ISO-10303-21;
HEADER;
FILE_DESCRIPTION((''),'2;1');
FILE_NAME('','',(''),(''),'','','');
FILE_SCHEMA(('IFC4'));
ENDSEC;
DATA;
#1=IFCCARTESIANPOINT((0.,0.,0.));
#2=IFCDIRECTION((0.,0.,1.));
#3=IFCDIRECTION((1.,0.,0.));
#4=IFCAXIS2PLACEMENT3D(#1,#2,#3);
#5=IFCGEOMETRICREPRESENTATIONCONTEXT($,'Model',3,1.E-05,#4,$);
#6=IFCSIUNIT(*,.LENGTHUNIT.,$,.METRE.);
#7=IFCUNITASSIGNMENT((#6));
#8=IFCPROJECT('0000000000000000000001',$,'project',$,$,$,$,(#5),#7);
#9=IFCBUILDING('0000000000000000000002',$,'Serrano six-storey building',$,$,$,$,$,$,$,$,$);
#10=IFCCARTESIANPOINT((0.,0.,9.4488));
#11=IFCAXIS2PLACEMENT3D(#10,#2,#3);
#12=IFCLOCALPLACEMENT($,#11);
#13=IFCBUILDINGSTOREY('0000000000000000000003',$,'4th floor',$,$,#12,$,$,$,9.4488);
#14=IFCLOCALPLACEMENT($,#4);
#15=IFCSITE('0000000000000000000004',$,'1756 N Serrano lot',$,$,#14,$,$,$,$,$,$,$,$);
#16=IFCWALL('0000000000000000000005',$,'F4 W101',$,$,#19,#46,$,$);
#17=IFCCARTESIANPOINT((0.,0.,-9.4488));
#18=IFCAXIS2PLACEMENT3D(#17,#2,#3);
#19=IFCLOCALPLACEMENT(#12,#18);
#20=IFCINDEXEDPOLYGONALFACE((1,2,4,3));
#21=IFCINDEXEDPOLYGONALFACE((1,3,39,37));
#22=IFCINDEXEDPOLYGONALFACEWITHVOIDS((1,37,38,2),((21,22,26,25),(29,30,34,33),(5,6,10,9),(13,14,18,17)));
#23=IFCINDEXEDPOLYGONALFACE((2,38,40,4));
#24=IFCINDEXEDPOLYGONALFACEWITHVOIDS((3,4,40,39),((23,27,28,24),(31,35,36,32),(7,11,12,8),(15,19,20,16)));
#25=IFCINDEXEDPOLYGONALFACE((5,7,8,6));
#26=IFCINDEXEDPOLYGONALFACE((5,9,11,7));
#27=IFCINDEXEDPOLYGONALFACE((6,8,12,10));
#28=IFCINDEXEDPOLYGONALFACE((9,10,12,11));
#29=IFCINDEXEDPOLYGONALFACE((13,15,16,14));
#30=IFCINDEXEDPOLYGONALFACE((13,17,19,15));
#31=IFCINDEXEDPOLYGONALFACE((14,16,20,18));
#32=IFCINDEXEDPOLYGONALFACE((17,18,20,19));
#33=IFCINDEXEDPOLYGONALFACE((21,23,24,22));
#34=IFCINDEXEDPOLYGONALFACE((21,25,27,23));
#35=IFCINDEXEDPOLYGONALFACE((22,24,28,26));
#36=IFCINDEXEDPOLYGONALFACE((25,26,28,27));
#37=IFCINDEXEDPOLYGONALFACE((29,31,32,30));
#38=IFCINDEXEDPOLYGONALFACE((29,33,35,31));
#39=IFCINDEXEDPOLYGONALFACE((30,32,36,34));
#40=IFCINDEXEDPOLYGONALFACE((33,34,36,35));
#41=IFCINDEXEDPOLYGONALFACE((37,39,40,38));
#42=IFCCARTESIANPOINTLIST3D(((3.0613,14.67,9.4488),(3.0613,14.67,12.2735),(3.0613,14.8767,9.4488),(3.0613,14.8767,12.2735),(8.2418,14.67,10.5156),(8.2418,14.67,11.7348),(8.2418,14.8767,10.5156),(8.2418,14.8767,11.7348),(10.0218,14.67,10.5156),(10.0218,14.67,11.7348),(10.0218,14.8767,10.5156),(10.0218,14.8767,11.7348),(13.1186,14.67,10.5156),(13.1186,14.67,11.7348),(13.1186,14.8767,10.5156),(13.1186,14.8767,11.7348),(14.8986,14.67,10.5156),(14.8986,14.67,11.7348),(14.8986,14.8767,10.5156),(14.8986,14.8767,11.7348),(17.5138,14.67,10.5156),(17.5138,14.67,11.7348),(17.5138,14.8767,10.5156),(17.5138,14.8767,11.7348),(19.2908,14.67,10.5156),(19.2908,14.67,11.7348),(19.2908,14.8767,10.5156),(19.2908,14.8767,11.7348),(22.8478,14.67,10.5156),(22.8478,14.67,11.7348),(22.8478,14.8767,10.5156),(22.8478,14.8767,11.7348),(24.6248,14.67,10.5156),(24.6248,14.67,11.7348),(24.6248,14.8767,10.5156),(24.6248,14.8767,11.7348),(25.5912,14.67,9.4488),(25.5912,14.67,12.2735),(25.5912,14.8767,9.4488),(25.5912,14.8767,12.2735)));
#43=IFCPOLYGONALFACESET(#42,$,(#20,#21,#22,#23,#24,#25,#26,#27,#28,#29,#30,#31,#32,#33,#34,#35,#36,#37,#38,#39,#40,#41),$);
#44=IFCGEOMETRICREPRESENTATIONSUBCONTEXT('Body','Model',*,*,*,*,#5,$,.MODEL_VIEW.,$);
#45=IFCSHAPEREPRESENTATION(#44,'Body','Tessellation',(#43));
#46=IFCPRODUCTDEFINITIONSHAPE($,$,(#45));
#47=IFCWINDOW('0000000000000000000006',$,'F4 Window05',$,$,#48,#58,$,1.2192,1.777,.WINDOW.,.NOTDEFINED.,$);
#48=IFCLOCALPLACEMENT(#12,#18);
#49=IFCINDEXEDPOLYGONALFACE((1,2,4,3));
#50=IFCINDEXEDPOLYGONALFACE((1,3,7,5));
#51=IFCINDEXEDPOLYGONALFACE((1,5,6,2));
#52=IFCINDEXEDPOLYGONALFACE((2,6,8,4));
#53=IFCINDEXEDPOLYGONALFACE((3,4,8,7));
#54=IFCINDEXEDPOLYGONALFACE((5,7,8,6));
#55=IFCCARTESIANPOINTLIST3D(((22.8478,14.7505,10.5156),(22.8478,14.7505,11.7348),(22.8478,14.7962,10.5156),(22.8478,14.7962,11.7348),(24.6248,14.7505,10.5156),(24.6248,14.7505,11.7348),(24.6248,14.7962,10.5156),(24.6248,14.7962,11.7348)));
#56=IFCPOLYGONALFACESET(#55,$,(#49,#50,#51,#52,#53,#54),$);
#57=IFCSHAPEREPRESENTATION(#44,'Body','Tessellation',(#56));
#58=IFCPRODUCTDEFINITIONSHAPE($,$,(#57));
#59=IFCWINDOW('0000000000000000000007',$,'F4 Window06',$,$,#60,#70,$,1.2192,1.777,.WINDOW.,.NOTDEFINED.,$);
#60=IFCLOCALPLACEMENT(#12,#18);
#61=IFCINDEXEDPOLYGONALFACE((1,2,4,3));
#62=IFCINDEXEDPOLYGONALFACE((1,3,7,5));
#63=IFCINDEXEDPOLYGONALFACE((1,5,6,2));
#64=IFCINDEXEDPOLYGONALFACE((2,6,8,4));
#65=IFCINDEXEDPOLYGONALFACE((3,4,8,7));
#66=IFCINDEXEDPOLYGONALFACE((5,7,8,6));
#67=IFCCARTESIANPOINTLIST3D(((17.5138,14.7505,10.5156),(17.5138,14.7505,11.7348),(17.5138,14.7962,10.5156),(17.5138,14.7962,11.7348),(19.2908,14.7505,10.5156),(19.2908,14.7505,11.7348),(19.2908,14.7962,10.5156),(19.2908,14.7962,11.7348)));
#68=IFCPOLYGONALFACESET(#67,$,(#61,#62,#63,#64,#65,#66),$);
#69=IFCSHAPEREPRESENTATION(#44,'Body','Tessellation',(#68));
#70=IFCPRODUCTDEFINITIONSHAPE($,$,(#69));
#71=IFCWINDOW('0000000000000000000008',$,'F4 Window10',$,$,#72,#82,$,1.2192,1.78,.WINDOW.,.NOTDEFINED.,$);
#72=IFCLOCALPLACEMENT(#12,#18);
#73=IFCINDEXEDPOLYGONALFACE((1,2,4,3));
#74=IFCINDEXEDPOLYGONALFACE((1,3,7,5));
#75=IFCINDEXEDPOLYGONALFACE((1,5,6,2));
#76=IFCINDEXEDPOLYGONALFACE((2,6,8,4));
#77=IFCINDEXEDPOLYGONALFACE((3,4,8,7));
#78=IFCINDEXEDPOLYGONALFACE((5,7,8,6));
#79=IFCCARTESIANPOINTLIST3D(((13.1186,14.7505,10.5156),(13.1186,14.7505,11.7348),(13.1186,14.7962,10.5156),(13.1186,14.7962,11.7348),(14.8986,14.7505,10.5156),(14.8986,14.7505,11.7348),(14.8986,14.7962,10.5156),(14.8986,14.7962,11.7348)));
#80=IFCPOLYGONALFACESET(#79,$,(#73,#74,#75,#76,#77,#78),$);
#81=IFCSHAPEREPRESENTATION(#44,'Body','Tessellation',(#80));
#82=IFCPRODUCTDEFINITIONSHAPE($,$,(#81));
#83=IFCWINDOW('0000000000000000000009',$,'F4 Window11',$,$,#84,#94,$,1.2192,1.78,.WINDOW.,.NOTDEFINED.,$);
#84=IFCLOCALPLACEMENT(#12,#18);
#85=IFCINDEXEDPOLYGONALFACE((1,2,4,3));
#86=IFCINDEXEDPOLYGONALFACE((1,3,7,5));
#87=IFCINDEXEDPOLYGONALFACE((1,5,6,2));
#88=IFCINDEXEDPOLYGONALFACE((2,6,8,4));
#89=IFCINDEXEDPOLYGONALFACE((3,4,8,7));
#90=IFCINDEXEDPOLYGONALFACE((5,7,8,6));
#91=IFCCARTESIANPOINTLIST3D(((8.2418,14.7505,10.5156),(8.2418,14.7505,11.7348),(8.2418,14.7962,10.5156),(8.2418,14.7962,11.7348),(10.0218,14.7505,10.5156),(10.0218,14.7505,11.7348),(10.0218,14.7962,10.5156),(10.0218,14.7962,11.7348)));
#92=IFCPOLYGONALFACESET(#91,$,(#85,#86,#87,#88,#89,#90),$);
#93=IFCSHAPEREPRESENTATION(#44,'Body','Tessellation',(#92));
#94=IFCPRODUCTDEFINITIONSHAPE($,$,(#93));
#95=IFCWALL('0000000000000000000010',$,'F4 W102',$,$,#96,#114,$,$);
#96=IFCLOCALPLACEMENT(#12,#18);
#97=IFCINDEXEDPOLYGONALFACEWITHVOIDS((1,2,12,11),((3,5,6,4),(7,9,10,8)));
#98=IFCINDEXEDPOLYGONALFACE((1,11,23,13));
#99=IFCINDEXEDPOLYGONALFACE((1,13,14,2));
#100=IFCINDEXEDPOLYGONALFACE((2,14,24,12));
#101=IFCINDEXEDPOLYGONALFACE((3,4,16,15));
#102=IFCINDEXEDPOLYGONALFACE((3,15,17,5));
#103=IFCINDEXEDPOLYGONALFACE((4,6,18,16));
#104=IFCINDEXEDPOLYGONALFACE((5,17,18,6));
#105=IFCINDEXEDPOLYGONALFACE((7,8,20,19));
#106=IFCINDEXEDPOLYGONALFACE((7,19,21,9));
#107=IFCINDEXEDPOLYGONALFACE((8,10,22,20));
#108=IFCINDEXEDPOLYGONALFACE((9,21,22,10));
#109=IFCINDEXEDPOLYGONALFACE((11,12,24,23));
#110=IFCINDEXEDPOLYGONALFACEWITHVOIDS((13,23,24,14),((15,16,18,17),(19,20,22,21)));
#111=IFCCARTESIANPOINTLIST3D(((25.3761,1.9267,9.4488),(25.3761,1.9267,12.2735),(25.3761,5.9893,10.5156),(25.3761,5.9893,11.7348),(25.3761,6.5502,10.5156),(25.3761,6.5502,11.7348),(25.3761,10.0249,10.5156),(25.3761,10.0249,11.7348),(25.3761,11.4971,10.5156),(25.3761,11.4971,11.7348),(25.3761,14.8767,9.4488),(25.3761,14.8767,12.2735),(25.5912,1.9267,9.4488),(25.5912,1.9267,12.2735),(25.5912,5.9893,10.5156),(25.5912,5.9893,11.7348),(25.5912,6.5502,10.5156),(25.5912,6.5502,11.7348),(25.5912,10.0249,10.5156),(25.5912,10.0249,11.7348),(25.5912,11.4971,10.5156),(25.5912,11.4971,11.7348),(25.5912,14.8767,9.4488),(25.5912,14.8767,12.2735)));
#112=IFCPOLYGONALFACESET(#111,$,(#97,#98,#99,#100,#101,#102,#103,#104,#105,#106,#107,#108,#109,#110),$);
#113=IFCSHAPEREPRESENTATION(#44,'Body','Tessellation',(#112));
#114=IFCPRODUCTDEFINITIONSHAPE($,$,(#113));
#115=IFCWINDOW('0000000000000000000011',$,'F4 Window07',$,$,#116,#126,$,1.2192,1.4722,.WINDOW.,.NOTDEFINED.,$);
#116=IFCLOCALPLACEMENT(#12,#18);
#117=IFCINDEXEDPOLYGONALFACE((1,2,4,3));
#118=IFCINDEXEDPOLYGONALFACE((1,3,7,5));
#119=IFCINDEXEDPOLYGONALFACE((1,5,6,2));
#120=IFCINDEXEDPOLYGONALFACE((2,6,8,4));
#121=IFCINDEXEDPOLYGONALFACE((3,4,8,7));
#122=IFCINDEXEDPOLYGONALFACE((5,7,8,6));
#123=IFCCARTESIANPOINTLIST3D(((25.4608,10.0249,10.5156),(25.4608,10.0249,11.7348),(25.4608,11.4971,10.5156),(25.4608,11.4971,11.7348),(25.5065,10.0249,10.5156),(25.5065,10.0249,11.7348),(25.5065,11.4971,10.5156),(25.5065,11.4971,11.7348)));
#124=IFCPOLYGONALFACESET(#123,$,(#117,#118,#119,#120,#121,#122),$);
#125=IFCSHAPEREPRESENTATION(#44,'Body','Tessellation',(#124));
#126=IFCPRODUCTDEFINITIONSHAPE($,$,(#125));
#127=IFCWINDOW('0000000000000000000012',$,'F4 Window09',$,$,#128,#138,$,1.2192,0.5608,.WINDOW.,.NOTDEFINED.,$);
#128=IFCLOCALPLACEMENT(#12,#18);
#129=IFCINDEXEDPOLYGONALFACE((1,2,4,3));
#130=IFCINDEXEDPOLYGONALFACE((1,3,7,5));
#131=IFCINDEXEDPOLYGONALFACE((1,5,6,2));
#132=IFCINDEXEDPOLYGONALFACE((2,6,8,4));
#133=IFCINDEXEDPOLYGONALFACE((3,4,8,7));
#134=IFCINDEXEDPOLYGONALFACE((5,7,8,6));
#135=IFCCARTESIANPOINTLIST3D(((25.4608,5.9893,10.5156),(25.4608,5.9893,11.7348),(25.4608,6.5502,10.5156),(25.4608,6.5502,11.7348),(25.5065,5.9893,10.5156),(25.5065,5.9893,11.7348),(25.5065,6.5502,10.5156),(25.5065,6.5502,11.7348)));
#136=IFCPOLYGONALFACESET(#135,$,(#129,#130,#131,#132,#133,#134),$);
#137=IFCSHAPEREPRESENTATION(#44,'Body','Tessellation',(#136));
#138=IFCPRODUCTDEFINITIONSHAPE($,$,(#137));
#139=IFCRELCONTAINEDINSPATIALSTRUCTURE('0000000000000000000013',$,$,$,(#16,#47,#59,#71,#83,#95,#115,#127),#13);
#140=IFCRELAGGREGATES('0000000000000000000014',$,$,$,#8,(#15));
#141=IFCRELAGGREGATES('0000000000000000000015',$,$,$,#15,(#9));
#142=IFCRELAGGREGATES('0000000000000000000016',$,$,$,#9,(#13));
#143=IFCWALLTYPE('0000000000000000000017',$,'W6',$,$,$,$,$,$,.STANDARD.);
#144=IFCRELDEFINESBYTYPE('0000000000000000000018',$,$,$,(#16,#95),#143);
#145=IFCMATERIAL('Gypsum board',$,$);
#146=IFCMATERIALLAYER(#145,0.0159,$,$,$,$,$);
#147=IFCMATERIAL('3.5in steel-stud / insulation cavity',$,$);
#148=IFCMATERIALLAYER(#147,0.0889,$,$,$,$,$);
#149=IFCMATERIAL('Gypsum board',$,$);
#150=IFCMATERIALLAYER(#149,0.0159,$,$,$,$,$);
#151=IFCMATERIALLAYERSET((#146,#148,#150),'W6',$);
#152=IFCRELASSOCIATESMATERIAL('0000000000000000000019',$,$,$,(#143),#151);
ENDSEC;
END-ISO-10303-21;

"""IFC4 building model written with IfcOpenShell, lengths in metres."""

from ifc_helpers import new_model, si_unit, frame, origin_with_axes, place, context, subcontext, project, spatial, polyline, outline, extrude, material, layer, layer_set, type_object, element, fill, save


model = new_model("IFC4")

# Units and contexts
model_context = context("Model", 3, precision=1e-05, world=origin_with_axes())
body_context = subcontext(model_context, "Body", "Model", "MODEL_VIEW")
ifc_project = project(units=[si_unit("LENGTHUNIT", "METRE")], contexts=[model_context])

# Site, building, storey
site_placement = place(None, origin_with_axes())
site = spatial("IfcSite", under=ifc_project, at=site_placement, Name="1756 N Serrano lot")
building = spatial("IfcBuilding", under=site, Name="Serrano six-storey building")
storey_placement = place(None, frame((0.0, 0.0, 9.4488), z_axis=(0.0, 0.0, 1.0), x_axis=(1.0, 0.0, 0.0)))
storey = spatial("IfcBuildingStorey", under=building, at=storey_placement, Name="4th floor", Elevation=9.4488)

# Walls, openings, windows
ifc_material_1 = material(Name="Gypsum board")
ifc_layer_1 = layer(ifc_material_1, 0.0159)
ifc_material_2 = material(Name="3.5in steel-stud / insulation cavity")
ifc_layer_2 = layer(ifc_material_2, 0.0889)
ifc_material_3 = material(Name="Gypsum board")
ifc_layer_3 = layer(ifc_material_3, 0.0159)
ifc_layer_set = layer_set([ifc_layer_1, ifc_layer_2, ifc_layer_3], Name="W6")
wall_type_1 = type_object("IfcWallType", Name="W6", PredefinedType="STANDARD", material=ifc_layer_set)
wall_1_placement = place(storey_placement, frame((0.0, 0.0, -9.4488), z_axis=(0.0, 0.0, 1.0), x_axis=(1.0, 0.0, 0.0)))
wall_1 = element("IfcWall", 1, at=wall_1_placement, inside=storey, type_object=wall_type_1, Name="F4 W101", context=body_context, shape_type="SweptSolid", body=[
    extrude(outline(polyline([(25.5912, 14.8767), (25.5912, 14.67), (3.0613, 14.67), (3.0613, 14.8767), (25.5912, 14.8767)])), frame((0.0, 0.0, 9.4488)), (0.0, 0.0, 1.0), 2.8247),
])
opening_1_placement = place(None, origin_with_axes())
opening_1 = element("IfcOpeningElement", 2, at=opening_1_placement, cuts=wall_1, PredefinedType="OPENING", context=body_context, shape_type="SweptSolid", body=[
    extrude(outline(polyline([(24.6248, 14.895), (24.6248, 14.6517), (22.8478, 14.6517), (22.8478, 14.895), (24.6248, 14.895)])), frame((0.0, 0.0, 10.5156)), (0.0, 0.0, 1.0), 1.2192),
])
opening_2_placement = place(None, origin_with_axes())
opening_2 = element("IfcOpeningElement", 3, at=opening_2_placement, cuts=wall_1, PredefinedType="OPENING", context=body_context, shape_type="SweptSolid", body=[
    extrude(outline(polyline([(19.2908, 14.895), (19.2908, 14.6517), (17.5138, 14.6517), (17.5138, 14.895), (19.2908, 14.895)])), frame((0.0, 0.0, 10.5156)), (0.0, 0.0, 1.0), 1.2192),
])
opening_3_placement = place(None, origin_with_axes())
opening_3 = element("IfcOpeningElement", 4, at=opening_3_placement, cuts=wall_1, PredefinedType="OPENING", context=body_context, shape_type="SweptSolid", body=[
    extrude(outline(polyline([(14.8986, 14.895), (14.8986, 14.6517), (13.1186, 14.6517), (13.1186, 14.895), (14.8986, 14.895)])), frame((0.0, 0.0, 10.5156)), (0.0, 0.0, 1.0), 1.2192),
])
opening_4_placement = place(None, origin_with_axes())
opening_4 = element("IfcOpeningElement", 5, at=opening_4_placement, cuts=wall_1, PredefinedType="OPENING", context=body_context, shape_type="SweptSolid", body=[
    extrude(outline(polyline([(10.0218, 14.895), (10.0218, 14.6517), (8.2418, 14.6517), (8.2418, 14.895), (10.0218, 14.895)])), frame((0.0, 0.0, 10.5156)), (0.0, 0.0, 1.0), 1.2192),
])
window_1_placement = place(storey_placement, frame((0.0, 0.0, -9.4488), z_axis=(0.0, 0.0, 1.0), x_axis=(1.0, 0.0, 0.0)))
window_1 = element("IfcWindow", 6, at=window_1_placement, inside=storey, Name="F4 Window05", OverallHeight=1.2192, OverallWidth=1.777, PartitioningType="NOTDEFINED", PredefinedType="WINDOW", context=body_context, shape_type="SweptSolid", body=[
    extrude(outline(polyline([(24.6248, 14.7962), (24.6248, 14.7505), (22.8478, 14.7505), (22.8478, 14.7962), (24.6248, 14.7962)])), frame((0.0, 0.0, 10.5156)), (0.0, 0.0, 1.0), 1.2192),
])
fill(opening_1, window_1)
window_2_placement = place(storey_placement, frame((0.0, 0.0, -9.4488), z_axis=(0.0, 0.0, 1.0), x_axis=(1.0, 0.0, 0.0)))
window_2 = element("IfcWindow", 7, at=window_2_placement, inside=storey, Name="F4 Window06", OverallHeight=1.2192, OverallWidth=1.777, PartitioningType="NOTDEFINED", PredefinedType="WINDOW", context=body_context, shape_type="SweptSolid", body=[
    extrude(outline(polyline([(19.2908, 14.7962), (19.2908, 14.7505), (17.5138, 14.7505), (17.5138, 14.7962), (19.2908, 14.7962)])), frame((0.0, 0.0, 10.5156)), (0.0, 0.0, 1.0), 1.2192),
])
fill(opening_2, window_2)
window_3_placement = place(storey_placement, frame((0.0, 0.0, -9.4488), z_axis=(0.0, 0.0, 1.0), x_axis=(1.0, 0.0, 0.0)))
window_3 = element("IfcWindow", 8, at=window_3_placement, inside=storey, Name="F4 Window10", OverallHeight=1.2192, OverallWidth=1.78, PartitioningType="NOTDEFINED", PredefinedType="WINDOW", context=body_context, shape_type="SweptSolid", body=[
    extrude(outline(polyline([(14.8986, 14.7962), (14.8986, 14.7505), (13.1186, 14.7505), (13.1186, 14.7962), (14.8986, 14.7962)])), frame((0.0, 0.0, 10.5156)), (0.0, 0.0, 1.0), 1.2192),
])
fill(opening_3, window_3)
window_4_placement = place(storey_placement, frame((0.0, 0.0, -9.4488), z_axis=(0.0, 0.0, 1.0), x_axis=(1.0, 0.0, 0.0)))
window_4 = element("IfcWindow", 9, at=window_4_placement, inside=storey, Name="F4 Window11", OverallHeight=1.2192, OverallWidth=1.78, PartitioningType="NOTDEFINED", PredefinedType="WINDOW", context=body_context, shape_type="SweptSolid", body=[
    extrude(outline(polyline([(10.0218, 14.7962), (10.0218, 14.7505), (8.2418, 14.7505), (8.2418, 14.7962), (10.0218, 14.7962)])), frame((0.0, 0.0, 10.5156)), (0.0, 0.0, 1.0), 1.2192),
])
fill(opening_4, window_4)
wall_2_placement = place(storey_placement, frame((0.0, 0.0, -9.4488), z_axis=(0.0, 0.0, 1.0), x_axis=(1.0, 0.0, 0.0)))
wall_2 = element("IfcWall", 10, at=wall_2_placement, inside=storey, type_object=wall_type_1, Name="F4 W102", context=body_context, shape_type="SweptSolid", body=[
    extrude(outline(polyline([(25.5912, 1.9267), (25.3761, 1.9267), (25.3761, 14.8767), (25.5912, 14.8767), (25.5912, 1.9267)])), frame((0.0, 0.0, 9.4488)), (0.0, 0.0, 1.0), 2.8247),
])
opening_5_placement = place(None, origin_with_axes())
opening_5 = element("IfcOpeningElement", 11, at=opening_5_placement, cuts=wall_2, PredefinedType="OPENING", context=body_context, shape_type="SweptSolid", body=[
    extrude(outline(polyline([(25.3578, 11.4971), (25.6095, 11.4971), (25.6095, 10.0249), (25.3578, 10.0249), (25.3578, 11.4971)])), frame((0.0, 0.0, 10.5156)), (0.0, 0.0, 1.0), 1.2192),
])
opening_6_placement = place(None, origin_with_axes())
opening_6 = element("IfcOpeningElement", 12, at=opening_6_placement, cuts=wall_2, PredefinedType="OPENING", context=body_context, shape_type="SweptSolid", body=[
    extrude(outline(polyline([(25.3578, 6.5502), (25.6095, 6.5502), (25.6095, 5.9893), (25.3578, 5.9893), (25.3578, 6.5502)])), frame((0.0, 0.0, 10.5156)), (0.0, 0.0, 1.0), 1.2192),
])
window_5_placement = place(storey_placement, frame((0.0, 0.0, -9.4488), z_axis=(0.0, 0.0, 1.0), x_axis=(1.0, 0.0, 0.0)))
window_5 = element("IfcWindow", 13, at=window_5_placement, inside=storey, Name="F4 Window07", OverallHeight=1.2192, OverallWidth=1.4722, PartitioningType="NOTDEFINED", PredefinedType="WINDOW", context=body_context, shape_type="SweptSolid", body=[
    extrude(outline(polyline([(25.4608, 11.4971), (25.5065, 11.4971), (25.5065, 10.0249), (25.4608, 10.0249), (25.4608, 11.4971)])), frame((0.0, 0.0, 10.5156)), (0.0, 0.0, 1.0), 1.2192),
])
fill(opening_5, window_5)
window_6_placement = place(storey_placement, frame((0.0, 0.0, -9.4488), z_axis=(0.0, 0.0, 1.0), x_axis=(1.0, 0.0, 0.0)))
window_6 = element("IfcWindow", 14, at=window_6_placement, inside=storey, Name="F4 Window09", OverallHeight=1.2192, OverallWidth=0.5608, PartitioningType="NOTDEFINED", PredefinedType="WINDOW", context=body_context, shape_type="SweptSolid", body=[
    extrude(outline(polyline([(25.4608, 6.5502), (25.5065, 6.5502), (25.5065, 5.9893), (25.4608, 5.9893), (25.4608, 6.5502)])), frame((0.0, 0.0, 10.5156)), (0.0, 0.0, 1.0), 1.2192),
])
fill(opening_6, window_6)

save(model, "model.ifc")
